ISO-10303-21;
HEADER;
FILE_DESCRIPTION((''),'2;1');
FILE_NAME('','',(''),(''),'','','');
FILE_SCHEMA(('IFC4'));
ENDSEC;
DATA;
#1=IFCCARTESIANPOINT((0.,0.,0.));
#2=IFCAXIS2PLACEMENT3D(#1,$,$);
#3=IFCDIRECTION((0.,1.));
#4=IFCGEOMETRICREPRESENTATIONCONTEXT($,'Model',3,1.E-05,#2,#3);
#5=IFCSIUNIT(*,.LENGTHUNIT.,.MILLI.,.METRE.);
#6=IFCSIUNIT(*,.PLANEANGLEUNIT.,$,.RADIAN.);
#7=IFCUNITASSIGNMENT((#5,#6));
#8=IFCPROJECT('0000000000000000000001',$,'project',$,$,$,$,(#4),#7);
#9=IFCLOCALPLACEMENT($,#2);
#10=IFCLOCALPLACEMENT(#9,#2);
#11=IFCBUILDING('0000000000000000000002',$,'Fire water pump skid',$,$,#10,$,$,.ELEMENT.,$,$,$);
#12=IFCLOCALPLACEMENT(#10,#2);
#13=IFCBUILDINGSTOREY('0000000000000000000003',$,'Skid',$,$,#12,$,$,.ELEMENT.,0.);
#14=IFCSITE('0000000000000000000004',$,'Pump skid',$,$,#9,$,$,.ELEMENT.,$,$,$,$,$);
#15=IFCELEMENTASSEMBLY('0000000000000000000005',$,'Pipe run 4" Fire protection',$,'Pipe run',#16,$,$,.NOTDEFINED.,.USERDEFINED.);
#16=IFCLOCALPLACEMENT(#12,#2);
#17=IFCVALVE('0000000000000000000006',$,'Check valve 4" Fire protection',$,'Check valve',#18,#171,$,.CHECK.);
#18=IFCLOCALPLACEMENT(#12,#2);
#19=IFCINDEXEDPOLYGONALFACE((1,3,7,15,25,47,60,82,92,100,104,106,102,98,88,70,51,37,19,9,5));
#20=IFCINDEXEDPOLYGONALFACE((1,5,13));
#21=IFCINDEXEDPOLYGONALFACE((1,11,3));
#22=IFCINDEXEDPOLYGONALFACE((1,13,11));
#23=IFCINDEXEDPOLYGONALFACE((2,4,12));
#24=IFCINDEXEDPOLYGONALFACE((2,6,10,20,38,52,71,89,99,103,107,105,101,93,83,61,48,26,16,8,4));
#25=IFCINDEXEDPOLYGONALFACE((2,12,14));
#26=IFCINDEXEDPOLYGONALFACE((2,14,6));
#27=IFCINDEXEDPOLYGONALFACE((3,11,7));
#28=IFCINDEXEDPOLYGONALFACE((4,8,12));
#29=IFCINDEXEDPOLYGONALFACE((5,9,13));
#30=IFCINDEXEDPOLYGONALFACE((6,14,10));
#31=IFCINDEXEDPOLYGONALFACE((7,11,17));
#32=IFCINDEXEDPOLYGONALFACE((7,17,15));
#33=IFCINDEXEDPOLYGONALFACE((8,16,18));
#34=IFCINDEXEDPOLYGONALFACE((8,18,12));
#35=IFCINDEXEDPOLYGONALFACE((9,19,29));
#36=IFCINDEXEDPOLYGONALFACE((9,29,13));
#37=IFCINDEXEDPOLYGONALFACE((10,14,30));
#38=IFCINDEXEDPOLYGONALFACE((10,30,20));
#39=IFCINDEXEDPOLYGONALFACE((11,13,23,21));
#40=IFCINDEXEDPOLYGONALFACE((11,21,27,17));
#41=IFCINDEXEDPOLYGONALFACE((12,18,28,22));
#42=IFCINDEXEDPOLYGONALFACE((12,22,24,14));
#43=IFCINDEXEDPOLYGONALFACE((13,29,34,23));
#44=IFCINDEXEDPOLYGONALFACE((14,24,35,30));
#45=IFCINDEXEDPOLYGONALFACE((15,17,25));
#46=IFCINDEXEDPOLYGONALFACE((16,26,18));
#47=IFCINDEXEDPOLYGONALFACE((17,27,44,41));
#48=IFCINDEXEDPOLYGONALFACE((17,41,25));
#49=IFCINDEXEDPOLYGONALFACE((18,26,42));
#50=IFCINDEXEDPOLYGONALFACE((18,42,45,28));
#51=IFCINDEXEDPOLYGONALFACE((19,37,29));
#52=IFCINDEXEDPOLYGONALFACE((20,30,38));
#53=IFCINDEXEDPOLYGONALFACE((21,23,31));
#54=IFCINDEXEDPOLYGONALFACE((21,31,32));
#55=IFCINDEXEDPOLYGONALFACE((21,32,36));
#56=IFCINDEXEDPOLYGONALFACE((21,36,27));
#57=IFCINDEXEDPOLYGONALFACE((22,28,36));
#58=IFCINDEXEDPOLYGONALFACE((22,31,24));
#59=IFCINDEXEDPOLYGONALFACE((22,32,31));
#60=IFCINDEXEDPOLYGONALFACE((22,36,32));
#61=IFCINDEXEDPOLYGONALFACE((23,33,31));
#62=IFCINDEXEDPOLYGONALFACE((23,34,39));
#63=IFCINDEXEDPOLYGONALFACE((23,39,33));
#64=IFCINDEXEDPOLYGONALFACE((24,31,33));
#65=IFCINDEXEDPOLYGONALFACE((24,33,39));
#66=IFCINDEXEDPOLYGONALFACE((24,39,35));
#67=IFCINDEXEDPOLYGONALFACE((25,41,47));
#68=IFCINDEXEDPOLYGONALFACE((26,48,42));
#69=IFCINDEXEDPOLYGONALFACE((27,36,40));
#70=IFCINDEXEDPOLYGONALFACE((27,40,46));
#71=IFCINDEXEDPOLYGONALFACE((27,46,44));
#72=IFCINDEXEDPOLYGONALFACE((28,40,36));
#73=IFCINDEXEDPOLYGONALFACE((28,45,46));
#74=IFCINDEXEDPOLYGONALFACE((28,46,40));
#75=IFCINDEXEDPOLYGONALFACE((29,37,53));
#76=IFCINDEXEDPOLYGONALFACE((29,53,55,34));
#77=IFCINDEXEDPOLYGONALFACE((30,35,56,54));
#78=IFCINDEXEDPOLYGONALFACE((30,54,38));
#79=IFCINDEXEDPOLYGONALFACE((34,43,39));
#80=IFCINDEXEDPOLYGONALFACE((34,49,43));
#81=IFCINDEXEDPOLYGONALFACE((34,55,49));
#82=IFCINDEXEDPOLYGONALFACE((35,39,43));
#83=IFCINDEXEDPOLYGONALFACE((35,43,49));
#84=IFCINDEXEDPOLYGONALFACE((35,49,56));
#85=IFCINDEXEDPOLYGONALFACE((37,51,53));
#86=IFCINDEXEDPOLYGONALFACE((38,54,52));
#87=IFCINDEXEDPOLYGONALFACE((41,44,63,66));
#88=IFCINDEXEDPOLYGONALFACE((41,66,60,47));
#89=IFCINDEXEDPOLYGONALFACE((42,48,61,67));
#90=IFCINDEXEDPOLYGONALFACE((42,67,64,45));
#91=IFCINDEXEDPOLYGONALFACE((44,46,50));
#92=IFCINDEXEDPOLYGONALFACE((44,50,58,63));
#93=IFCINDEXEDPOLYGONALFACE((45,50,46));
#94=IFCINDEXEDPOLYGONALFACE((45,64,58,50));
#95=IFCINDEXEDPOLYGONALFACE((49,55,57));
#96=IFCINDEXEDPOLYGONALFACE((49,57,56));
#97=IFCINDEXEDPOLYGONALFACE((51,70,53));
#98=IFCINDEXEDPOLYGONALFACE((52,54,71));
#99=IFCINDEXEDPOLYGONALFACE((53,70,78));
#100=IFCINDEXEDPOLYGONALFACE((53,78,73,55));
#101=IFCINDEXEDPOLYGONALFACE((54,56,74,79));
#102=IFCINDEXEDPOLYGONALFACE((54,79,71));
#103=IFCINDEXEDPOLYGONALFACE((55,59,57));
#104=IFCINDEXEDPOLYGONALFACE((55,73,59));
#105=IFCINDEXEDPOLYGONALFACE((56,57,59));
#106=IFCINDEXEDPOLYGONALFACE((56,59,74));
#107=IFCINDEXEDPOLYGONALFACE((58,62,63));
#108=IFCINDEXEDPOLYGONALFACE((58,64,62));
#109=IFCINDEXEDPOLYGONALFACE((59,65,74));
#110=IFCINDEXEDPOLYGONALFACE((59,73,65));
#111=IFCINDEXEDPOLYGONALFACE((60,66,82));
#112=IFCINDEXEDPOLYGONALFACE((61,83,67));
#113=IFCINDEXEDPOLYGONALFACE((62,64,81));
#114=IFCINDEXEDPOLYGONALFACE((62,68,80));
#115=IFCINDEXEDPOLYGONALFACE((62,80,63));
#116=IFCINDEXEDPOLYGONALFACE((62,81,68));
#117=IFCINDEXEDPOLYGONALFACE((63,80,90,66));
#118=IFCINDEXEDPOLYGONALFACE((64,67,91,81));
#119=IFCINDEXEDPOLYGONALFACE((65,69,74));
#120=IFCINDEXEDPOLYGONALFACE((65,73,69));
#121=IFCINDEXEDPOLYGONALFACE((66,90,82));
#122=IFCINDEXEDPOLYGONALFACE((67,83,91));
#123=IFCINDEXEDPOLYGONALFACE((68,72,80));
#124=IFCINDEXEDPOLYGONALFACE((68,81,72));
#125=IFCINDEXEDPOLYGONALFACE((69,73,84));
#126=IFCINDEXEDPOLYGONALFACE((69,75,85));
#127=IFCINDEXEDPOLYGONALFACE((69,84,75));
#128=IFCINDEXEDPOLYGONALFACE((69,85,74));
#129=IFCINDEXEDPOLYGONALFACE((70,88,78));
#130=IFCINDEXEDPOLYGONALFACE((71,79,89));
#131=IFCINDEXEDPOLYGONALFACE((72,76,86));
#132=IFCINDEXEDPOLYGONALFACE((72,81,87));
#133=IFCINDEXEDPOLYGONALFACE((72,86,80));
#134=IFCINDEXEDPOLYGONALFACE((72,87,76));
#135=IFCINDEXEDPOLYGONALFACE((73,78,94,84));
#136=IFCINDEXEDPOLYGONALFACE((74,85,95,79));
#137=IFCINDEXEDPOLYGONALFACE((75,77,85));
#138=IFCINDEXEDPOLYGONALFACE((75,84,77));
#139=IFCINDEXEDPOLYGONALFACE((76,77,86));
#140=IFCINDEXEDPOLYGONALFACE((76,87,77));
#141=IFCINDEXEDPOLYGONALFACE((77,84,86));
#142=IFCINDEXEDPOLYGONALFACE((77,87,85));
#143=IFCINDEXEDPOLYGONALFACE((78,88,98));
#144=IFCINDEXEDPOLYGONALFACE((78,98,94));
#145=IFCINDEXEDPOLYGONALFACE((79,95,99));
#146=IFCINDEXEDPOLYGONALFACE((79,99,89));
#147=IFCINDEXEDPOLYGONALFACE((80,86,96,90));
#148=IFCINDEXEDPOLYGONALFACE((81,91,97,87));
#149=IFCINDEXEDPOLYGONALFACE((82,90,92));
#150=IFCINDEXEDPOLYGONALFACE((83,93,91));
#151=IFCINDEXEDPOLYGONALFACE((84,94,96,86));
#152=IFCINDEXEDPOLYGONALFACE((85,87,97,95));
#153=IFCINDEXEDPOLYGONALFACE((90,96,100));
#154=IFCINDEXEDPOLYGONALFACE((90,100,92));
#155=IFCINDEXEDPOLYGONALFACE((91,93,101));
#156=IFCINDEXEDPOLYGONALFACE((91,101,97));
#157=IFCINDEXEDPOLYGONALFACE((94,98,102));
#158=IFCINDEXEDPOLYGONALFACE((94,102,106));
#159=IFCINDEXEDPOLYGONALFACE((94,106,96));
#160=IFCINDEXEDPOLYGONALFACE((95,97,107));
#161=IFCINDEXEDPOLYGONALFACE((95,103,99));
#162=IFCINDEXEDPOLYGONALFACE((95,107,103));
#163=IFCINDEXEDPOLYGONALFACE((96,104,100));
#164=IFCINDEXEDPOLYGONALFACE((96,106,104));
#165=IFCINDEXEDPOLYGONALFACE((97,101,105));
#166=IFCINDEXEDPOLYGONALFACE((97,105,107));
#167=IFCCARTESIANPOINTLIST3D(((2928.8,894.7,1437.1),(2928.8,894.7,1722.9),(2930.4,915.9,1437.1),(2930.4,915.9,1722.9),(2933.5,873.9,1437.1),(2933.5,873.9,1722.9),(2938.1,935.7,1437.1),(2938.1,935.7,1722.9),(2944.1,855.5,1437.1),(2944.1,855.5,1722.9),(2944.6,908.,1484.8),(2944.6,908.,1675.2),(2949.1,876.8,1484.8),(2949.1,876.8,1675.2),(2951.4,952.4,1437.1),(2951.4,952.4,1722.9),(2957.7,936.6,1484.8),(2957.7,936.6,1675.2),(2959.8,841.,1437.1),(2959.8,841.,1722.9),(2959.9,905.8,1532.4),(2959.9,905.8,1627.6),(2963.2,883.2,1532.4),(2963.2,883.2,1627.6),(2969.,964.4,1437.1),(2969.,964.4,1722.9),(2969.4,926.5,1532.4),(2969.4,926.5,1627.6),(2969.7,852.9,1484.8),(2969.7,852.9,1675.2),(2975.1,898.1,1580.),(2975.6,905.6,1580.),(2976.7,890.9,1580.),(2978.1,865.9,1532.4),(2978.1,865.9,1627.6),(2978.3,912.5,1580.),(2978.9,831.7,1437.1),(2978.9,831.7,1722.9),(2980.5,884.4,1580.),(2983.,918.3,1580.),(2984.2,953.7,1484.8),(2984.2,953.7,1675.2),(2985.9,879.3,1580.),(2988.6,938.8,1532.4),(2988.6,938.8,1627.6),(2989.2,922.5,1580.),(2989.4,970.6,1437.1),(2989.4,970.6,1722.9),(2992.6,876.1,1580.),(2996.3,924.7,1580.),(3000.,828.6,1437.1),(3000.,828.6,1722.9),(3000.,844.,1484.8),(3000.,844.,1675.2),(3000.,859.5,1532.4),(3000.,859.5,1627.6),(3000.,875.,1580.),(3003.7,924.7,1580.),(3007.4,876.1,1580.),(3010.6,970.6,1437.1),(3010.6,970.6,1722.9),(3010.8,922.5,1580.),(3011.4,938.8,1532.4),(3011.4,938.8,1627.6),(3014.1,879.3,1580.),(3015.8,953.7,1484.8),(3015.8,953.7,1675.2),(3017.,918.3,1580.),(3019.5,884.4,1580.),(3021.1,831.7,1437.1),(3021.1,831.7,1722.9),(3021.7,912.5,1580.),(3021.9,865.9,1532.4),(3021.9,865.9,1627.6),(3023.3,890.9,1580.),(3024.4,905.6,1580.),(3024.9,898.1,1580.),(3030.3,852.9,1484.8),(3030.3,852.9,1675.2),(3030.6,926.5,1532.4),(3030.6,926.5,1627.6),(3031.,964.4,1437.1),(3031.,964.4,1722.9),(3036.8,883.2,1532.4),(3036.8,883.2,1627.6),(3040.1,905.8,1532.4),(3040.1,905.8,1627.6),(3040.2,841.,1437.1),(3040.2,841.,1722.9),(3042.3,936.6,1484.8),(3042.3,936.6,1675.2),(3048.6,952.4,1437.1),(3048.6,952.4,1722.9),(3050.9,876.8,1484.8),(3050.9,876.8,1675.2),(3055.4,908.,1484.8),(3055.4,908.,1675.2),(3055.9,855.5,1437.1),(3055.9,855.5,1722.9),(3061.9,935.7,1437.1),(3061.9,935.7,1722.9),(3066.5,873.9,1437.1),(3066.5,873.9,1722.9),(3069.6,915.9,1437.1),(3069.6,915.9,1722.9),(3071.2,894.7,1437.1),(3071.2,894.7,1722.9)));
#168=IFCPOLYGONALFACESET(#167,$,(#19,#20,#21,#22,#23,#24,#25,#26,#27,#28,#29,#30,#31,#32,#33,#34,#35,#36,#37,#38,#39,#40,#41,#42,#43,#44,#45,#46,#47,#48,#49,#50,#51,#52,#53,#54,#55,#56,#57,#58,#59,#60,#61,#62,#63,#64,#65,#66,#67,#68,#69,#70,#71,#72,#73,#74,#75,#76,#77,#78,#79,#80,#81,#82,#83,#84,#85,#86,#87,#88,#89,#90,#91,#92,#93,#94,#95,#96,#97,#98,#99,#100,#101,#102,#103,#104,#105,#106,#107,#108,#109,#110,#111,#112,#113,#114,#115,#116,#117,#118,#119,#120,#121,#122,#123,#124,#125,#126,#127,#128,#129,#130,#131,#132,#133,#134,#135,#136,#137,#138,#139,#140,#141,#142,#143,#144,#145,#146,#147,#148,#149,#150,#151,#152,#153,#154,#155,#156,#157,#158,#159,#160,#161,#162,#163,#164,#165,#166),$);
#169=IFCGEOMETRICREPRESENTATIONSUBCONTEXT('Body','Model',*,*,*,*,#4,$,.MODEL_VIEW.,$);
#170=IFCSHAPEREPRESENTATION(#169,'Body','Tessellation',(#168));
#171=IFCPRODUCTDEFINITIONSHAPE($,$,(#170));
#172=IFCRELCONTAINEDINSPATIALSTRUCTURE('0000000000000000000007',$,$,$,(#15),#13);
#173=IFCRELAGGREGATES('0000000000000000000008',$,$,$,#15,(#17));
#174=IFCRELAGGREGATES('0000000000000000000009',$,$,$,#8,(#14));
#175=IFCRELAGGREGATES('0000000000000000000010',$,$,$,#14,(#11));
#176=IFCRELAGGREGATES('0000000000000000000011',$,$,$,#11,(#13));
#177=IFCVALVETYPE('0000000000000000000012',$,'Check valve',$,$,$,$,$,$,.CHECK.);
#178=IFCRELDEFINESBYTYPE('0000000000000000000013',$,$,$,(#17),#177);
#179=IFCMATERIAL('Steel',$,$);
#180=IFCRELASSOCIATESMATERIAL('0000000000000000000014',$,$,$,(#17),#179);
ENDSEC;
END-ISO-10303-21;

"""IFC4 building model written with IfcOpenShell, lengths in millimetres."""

from ifc_helpers import new_model, entity, si_unit, direction, origin, origin_with_axes, place, context, subcontext, project, spatial, material, type_object, element, aggregate, save


model = new_model("IFC4")

# Units and contexts
model_context = context("Model", 3, precision=1e-05, world=origin(), true_north=direction((0.0, 1.0)))
body_context = subcontext(model_context, "Body", "Model", "MODEL_VIEW")
ifc_project = project(units=[si_unit("LENGTHUNIT", "METRE", prefix="MILLI"), si_unit("PLANEANGLEUNIT", "RADIAN")], contexts=[model_context])

# Site, building, storey
site_placement = place(None, origin())
site = spatial("IfcSite", under=ifc_project, at=site_placement, Name="Pump skid", CompositionType="ELEMENT")
building_placement = place(site_placement, origin())
building = spatial("IfcBuilding", under=site, at=building_placement, Name="Fire water pump skid", CompositionType="ELEMENT")
storey_placement = place(building_placement, origin())
storey = spatial("IfcBuildingStorey", under=building, at=storey_placement, Name="Skid", CompositionType="ELEMENT", Elevation=0.0)

# Element assembly
ifc_material = material(Name="Steel")
assembly_1_placement = place(storey_placement, origin_with_axes())
assembly_1 = element("IfcElementAssembly", 1, at=assembly_1_placement, inside=storey, Name="Pipe run 4\" Fire protection", ObjectType="Pipe run", AssemblyPlace="NOTDEFINED", PredefinedType="USERDEFINED")

# Valve
valve_type_1 = type_object("IfcValveType", Name="Check valve", PredefinedType="CHECK")
valve_1_placement = place(storey_placement, origin_with_axes())
cartesian_point_1 = entity("IfcCartesianPoint", [0.0, 0.0])
valve_1 = element("IfcValve", 2, at=valve_1_placement, type_object=valve_type_1, material=ifc_material, Name="Check valve 4\" Fire protection", ObjectType="Check valve", PredefinedType="CHECK", context=body_context, shape_type="SweptSolid", body=[
    entity("IfcRevolvedAreaSolid", entity("IfcArbitraryClosedProfileDef", "AREA", None, entity("IfcPolyline", [cartesian_point_1, entity("IfcCartesianPoint", [0.0, 71.4]), entity("IfcCartesianPoint", [142.9, 25.0]), entity("IfcCartesianPoint", [285.8, 71.4]), entity("IfcCartesianPoint", [285.8, 0.0]), cartesian_point_1])), entity("IfcAxis2Placement3D", entity("IfcCartesianPoint", [3000.0, 900.0, 1437.1]), entity("IfcDirection", [1.0, 0.0, 0.0]), entity("IfcDirection", [0.0, 0.0, 1.0])), entity("IfcAxis1Placement", entity("IfcCartesianPoint", [0.0, 0.0, 0.0]), entity("IfcDirection", [1.0, 0.0, 0.0])), 6.283185),
])
aggregate(assembly_1, [valve_1])

save(model, "model.ifc")
